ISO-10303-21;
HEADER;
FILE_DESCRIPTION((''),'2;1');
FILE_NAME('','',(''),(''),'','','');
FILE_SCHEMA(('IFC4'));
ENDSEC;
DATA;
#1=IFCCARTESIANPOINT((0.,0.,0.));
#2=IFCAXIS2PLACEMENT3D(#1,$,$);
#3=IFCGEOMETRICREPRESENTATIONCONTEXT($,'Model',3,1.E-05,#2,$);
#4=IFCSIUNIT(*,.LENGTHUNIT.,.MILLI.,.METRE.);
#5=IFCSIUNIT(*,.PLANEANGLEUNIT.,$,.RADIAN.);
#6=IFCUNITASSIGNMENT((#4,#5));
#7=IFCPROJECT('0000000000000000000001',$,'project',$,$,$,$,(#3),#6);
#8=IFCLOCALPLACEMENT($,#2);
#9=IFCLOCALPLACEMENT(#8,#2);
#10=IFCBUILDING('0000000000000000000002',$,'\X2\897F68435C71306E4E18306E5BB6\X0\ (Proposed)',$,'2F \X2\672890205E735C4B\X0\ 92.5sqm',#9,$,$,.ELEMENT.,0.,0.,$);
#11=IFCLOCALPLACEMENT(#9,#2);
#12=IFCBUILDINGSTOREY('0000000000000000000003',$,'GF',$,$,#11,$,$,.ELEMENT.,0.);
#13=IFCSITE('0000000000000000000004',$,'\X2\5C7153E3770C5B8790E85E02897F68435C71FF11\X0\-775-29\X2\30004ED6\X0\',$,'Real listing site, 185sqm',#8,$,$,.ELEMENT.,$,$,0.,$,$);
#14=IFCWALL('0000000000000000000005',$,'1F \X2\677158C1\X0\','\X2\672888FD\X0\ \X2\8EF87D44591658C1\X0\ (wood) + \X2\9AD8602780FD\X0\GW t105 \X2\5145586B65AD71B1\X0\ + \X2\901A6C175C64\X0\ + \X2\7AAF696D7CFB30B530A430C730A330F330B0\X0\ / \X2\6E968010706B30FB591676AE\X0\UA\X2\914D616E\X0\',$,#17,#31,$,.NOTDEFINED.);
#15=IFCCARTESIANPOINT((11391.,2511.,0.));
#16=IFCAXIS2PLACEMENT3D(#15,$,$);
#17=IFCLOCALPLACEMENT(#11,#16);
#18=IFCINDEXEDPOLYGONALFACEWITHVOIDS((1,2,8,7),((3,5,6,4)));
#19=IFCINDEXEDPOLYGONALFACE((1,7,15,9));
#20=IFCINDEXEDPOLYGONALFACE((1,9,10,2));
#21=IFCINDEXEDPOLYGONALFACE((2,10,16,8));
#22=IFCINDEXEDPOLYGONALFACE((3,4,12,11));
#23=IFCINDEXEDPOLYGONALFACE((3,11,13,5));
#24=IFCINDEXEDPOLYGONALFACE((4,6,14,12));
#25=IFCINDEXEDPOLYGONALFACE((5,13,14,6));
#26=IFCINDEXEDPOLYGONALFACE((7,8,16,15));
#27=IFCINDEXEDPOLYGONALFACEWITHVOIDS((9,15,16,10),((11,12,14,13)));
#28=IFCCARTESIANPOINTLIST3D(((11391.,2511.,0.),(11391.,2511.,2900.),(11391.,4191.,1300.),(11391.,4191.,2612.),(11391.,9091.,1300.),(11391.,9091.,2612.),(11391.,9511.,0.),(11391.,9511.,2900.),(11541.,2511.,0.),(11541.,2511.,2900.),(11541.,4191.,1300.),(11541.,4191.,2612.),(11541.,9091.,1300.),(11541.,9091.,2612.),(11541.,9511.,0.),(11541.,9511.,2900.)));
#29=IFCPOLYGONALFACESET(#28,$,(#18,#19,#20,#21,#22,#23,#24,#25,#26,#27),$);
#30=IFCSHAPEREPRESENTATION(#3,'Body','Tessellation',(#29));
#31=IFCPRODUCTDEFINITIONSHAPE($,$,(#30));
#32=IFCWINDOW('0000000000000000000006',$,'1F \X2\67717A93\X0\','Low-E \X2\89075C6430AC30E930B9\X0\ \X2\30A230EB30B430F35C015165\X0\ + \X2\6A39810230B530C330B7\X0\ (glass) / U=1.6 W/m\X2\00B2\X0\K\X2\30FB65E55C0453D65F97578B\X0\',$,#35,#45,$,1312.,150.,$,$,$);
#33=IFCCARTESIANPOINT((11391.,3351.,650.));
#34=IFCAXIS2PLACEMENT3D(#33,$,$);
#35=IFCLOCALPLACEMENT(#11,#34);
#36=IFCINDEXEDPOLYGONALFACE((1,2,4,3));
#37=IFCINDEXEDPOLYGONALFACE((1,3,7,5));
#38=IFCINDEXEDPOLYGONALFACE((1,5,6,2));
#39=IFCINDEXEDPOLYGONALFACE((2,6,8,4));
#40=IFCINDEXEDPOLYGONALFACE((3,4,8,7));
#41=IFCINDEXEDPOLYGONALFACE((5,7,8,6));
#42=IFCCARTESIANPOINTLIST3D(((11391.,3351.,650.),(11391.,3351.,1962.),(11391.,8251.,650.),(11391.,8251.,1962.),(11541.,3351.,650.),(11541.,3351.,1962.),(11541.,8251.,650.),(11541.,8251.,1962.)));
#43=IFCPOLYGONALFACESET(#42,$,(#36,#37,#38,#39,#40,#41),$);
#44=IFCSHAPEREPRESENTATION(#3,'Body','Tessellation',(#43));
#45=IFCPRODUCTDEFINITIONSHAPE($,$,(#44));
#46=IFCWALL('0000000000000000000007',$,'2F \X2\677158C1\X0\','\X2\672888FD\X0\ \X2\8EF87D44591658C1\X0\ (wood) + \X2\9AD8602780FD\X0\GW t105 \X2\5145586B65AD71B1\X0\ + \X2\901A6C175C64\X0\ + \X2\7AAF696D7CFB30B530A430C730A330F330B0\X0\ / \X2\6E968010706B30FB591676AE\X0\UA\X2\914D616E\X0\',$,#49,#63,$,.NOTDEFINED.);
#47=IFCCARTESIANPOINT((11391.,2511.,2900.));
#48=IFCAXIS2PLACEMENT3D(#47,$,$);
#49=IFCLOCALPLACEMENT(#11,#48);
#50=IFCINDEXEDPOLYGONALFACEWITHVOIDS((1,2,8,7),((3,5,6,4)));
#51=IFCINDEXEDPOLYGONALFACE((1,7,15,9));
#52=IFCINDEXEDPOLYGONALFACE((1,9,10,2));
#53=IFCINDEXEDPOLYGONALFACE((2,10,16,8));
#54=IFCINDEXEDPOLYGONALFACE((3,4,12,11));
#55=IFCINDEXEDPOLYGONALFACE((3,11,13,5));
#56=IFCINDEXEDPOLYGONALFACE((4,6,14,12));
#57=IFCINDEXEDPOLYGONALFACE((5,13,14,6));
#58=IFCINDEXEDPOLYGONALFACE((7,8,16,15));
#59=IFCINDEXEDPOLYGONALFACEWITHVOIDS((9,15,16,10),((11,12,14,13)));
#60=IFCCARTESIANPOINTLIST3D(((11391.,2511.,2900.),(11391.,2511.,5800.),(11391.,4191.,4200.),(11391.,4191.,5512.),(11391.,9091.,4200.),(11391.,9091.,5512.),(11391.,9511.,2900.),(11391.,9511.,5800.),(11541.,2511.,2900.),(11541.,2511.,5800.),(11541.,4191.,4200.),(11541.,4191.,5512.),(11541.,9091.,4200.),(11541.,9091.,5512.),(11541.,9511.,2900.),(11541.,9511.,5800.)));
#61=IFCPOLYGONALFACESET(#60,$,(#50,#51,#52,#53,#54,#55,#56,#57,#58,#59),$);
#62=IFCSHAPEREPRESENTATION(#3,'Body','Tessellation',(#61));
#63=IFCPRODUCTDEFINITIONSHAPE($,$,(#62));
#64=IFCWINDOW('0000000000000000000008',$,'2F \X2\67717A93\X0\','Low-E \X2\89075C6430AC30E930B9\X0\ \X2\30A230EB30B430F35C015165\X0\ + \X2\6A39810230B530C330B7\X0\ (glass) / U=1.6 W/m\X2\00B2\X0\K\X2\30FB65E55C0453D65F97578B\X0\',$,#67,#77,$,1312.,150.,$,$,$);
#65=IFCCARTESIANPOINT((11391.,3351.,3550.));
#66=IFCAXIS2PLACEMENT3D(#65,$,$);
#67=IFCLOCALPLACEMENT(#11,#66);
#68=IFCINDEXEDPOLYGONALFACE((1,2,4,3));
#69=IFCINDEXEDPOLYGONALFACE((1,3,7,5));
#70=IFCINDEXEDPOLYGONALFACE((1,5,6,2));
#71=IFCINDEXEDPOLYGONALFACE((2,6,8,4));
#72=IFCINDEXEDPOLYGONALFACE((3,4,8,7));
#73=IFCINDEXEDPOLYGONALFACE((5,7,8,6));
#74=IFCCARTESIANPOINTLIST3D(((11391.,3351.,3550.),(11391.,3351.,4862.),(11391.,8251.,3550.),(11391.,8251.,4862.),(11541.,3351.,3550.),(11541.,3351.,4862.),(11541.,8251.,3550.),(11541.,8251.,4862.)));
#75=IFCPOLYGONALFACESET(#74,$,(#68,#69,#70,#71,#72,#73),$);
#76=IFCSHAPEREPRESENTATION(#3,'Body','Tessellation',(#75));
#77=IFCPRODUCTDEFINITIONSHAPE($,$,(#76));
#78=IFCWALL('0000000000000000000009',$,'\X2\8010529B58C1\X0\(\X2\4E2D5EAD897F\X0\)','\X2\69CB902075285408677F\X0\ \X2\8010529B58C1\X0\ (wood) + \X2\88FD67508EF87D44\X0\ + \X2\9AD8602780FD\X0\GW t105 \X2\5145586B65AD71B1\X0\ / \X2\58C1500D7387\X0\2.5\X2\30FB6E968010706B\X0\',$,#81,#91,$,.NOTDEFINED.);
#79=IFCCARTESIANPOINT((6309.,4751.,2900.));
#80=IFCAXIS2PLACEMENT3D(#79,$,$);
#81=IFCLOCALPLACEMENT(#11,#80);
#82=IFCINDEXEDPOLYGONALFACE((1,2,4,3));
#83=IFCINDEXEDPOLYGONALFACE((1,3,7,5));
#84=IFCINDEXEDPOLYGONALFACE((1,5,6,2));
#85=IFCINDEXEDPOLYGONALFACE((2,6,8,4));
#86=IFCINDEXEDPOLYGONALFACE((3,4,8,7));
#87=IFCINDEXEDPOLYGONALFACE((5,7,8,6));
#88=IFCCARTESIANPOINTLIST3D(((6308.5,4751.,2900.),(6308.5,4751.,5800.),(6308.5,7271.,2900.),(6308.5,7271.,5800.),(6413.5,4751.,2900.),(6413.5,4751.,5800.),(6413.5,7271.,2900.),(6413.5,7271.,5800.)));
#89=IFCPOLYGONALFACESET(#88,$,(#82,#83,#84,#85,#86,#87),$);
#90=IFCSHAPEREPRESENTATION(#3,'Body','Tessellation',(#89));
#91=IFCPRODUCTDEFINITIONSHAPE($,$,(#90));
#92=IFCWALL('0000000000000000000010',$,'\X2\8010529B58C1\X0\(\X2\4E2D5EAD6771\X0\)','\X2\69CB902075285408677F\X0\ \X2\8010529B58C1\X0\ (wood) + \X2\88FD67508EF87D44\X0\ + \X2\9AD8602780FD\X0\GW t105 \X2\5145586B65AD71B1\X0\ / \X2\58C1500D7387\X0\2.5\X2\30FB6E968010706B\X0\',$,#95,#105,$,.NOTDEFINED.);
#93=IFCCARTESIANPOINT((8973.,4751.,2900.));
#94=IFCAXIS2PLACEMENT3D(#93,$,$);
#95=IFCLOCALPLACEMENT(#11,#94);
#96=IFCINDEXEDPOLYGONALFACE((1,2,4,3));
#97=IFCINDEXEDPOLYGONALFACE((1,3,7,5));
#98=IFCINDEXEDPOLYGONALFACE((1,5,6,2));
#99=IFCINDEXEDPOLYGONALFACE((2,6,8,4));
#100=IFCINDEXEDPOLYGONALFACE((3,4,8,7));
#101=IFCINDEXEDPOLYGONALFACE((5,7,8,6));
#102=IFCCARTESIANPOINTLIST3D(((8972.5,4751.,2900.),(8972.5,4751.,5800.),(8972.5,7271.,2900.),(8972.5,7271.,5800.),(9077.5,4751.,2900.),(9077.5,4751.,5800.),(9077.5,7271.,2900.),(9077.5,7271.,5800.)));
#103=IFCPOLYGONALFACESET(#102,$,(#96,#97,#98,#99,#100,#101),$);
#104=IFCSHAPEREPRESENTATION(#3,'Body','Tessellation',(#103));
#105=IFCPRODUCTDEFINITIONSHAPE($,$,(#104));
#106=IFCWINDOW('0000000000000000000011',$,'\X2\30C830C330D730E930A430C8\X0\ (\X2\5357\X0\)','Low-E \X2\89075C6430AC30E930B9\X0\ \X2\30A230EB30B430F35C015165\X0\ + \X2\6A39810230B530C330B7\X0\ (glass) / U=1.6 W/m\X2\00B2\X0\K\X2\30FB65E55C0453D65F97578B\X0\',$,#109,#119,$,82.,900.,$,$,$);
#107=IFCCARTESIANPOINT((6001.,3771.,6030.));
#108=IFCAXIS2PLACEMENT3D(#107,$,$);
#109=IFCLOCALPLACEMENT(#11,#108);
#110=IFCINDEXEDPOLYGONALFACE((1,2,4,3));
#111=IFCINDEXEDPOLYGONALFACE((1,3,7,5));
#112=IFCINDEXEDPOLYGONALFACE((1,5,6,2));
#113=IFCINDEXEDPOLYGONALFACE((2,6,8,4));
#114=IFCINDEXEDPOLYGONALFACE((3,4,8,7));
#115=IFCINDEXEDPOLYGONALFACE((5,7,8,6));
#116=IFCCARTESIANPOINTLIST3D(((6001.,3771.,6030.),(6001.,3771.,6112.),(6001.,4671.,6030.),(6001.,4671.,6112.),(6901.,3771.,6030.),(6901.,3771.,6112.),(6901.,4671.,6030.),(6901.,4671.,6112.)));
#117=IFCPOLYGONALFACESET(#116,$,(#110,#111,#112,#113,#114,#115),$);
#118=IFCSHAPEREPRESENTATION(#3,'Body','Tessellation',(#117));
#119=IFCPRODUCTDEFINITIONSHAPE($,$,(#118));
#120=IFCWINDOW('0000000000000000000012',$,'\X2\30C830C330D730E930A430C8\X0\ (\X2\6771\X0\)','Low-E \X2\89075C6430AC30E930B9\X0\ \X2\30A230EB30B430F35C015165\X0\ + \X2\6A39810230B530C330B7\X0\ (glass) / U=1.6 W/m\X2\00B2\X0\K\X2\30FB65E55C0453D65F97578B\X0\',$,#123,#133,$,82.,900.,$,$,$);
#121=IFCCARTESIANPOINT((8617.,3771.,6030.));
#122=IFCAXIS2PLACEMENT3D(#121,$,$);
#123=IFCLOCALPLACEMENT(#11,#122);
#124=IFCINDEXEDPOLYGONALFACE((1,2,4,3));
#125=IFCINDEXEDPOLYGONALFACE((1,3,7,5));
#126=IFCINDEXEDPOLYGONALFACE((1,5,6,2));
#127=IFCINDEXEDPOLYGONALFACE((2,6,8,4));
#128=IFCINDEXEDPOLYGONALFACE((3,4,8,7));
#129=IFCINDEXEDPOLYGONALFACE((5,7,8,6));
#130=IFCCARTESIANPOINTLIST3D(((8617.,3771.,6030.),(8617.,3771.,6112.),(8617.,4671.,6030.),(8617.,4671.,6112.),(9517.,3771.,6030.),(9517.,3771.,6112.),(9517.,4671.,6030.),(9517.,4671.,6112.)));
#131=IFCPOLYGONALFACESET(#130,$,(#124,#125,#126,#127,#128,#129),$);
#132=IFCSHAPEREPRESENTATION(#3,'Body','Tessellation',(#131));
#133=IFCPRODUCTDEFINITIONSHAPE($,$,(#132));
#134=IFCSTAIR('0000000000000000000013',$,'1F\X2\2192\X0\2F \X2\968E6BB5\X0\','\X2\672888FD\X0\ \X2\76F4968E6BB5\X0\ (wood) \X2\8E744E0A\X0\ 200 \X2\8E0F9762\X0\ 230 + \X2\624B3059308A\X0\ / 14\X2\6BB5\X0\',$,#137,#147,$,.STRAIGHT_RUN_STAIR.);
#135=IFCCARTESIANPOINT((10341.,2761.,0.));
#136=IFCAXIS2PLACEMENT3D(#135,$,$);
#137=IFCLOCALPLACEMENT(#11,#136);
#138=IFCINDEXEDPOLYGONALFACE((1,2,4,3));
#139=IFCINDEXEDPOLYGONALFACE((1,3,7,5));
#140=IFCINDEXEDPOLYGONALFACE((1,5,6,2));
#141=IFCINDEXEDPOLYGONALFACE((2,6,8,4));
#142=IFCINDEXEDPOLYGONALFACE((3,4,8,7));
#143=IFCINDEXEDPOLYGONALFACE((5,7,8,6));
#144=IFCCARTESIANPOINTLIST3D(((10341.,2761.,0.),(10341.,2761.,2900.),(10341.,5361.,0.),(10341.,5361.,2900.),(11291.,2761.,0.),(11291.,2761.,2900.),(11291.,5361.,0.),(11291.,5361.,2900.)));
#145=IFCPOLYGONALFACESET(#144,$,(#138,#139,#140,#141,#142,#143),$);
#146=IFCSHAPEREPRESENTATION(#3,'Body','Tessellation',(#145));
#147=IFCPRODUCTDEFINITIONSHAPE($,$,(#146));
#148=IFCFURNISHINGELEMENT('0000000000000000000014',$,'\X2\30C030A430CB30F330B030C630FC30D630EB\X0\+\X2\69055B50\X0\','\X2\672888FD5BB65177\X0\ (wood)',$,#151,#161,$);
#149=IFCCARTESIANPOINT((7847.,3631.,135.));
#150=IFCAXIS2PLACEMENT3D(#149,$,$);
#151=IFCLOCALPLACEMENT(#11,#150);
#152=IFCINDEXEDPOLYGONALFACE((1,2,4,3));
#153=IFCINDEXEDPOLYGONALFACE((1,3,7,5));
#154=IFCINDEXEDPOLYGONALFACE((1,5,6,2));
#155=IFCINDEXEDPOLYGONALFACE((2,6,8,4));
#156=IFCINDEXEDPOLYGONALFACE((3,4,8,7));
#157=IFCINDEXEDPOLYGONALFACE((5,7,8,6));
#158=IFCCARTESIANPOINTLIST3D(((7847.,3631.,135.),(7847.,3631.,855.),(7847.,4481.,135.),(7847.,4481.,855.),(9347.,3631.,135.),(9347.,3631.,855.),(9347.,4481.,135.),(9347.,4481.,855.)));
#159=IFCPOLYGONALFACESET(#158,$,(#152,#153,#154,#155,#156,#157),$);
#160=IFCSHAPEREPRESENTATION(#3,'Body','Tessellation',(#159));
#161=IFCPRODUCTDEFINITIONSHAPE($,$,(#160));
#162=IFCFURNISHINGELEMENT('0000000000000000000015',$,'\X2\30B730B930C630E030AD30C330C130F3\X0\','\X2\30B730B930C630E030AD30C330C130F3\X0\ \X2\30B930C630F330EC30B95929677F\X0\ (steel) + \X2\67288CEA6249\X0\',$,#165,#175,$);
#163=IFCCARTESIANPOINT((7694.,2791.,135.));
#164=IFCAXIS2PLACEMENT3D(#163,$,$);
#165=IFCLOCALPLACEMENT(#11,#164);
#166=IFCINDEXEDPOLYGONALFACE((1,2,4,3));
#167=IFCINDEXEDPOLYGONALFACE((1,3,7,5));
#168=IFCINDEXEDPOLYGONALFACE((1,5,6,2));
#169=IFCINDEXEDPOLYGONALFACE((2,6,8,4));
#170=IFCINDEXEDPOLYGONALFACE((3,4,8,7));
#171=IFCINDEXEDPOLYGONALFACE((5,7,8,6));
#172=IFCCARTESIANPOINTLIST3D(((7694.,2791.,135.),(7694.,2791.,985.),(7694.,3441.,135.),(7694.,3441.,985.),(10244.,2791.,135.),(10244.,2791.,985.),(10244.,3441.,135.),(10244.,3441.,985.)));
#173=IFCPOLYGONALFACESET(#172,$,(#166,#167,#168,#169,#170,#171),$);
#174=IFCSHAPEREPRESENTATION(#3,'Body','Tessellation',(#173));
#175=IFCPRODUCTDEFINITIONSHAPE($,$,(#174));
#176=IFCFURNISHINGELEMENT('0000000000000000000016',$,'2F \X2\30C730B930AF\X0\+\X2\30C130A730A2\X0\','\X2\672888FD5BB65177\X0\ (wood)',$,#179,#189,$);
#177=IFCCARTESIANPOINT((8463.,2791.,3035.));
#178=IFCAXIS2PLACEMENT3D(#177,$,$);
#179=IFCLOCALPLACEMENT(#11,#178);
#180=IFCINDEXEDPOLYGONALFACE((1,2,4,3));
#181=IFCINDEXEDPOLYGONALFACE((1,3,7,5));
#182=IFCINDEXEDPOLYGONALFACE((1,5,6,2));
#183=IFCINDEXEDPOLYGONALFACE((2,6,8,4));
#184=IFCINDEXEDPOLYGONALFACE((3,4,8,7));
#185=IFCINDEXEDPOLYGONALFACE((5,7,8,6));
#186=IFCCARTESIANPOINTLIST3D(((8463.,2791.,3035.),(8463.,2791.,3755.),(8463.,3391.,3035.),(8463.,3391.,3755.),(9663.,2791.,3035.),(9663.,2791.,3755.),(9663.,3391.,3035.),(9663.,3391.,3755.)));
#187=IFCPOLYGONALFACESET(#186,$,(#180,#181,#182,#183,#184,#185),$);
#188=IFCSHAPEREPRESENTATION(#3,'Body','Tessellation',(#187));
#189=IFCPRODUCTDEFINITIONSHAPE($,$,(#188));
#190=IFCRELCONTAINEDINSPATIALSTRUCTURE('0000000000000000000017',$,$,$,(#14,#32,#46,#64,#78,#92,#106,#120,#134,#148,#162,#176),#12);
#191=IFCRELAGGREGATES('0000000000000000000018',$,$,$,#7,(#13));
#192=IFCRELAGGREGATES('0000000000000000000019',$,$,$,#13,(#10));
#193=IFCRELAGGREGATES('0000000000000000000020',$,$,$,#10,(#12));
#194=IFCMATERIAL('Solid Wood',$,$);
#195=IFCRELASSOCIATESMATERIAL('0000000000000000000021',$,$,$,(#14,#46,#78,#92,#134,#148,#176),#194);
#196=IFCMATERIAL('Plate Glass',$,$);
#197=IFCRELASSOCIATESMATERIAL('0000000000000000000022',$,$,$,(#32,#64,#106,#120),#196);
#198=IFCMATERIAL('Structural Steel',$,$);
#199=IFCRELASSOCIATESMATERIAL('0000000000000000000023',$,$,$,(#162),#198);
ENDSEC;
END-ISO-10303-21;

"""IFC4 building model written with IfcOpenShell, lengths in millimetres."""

from ifc_helpers import new_model, si_unit, frame, frame_2d, origin, place, context, project, spatial, rectangle, extrude, material, element, fill, save


model = new_model("IFC4")

# Units and contexts
model_context = context("Model", 3, precision=1e-05, world=origin())
ifc_project = project(units=[si_unit("LENGTHUNIT", "METRE", prefix="MILLI"), si_unit("PLANEANGLEUNIT", "RADIAN")], contexts=[model_context])

# Site, building, storey
site_placement = place(None, origin())
site = spatial("IfcSite", under=ifc_project, at=site_placement, Name="山口県宇部市西桃山１-775-29　他", ObjectType="Real listing site, 185sqm", CompositionType="ELEMENT", RefElevation=0.0)
building_placement = place(site_placement, origin())
building = spatial("IfcBuilding", under=site, at=building_placement, Name="西桃山の丘の家 (Proposed)", ObjectType="2F 木造平屋 92.5sqm", CompositionType="ELEMENT", ElevationOfRefHeight=0.0, ElevationOfTerrain=0.0)
storey_placement = place(building_placement, origin())
storey = spatial("IfcBuildingStorey", under=building, at=storey_placement, Name="GF", CompositionType="ELEMENT", Elevation=0.0)

# Shared definitions
ifc_material_1 = material(Name="Solid Wood")

# Wall, opening, window
wall_1_placement = place(storey_placement, frame((11391.0, 2511.0, 0.0)))
wall_1 = element("IfcWall", 1, at=wall_1_placement, inside=storey, material=ifc_material_1, Name="1F 東壁", Description="木製 軸組外壁 (wood) + 高性能GW t105 充填断熱 + 通気層 + 窯業系サイディング / 準耐火・外皮UA配慮", PredefinedType="NOTDEFINED", context=model_context, shape_type="SweptSolid", body=[
    extrude(rectangle(XDim=150.0, YDim=7000.0, at=frame_2d((75.0, 3500.0))), frame((11391.0, 2511.0, 0.0)), (0.0, 0.0, 1.0), 2900.0),
])
opening_1_placement = place(storey_placement, frame((11391.0, 3351.0, 650.0)))
opening_1 = element("IfcOpeningElement", 2, at=opening_1_placement, cuts=wall_1, PredefinedType="NOTDEFINED", context=model_context, shape_type="SweptSolid", body=[
    extrude(rectangle(XDim=150.0, YDim=4900.0, at=frame_2d((75.0, 2450.0))), frame((11391.0, 3351.0, 650.0)), (0.0, 0.0, 1.0), 1312.0),
])
ifc_material_2 = material(Name="Plate Glass")
window_1_placement = place(storey_placement, frame((11391.0, 3351.0, 650.0)))
window_1 = element("IfcWindow", 3, at=window_1_placement, inside=storey, material=ifc_material_2, Name="1F 東窓", Description="Low-E 複層ガラス アルゴン封入 + 樹脂サッシ (glass) / U=1.6 W/m²K・日射取得型", OverallHeight=1312.0, OverallWidth=150.0, context=model_context, shape_type="SweptSolid", body=[
    extrude(rectangle(XDim=150.0, YDim=4900.0, at=frame_2d((75.0, 2450.0))), frame((11391.0, 3351.0, 650.0)), (0.0, 0.0, 1.0), 1312.0),
])
fill(opening_1, window_1)

# Wall, opening, window
wall_2_placement = place(storey_placement, frame((11391.0, 2511.0, 2900.0)))
wall_2 = element("IfcWall", 4, at=wall_2_placement, inside=storey, material=ifc_material_1, Name="2F 東壁", Description="木製 軸組外壁 (wood) + 高性能GW t105 充填断熱 + 通気層 + 窯業系サイディング / 準耐火・外皮UA配慮", PredefinedType="NOTDEFINED", context=model_context, shape_type="SweptSolid", body=[
    extrude(rectangle(XDim=150.0, YDim=7000.0, at=frame_2d((75.0, 3500.0))), frame((11391.0, 2511.0, 2900.0)), (0.0, 0.0, 1.0), 2900.0),
])
opening_2_placement = place(storey_placement, frame((11391.0, 3351.0, 3550.0)))
opening_2 = element("IfcOpeningElement", 5, at=opening_2_placement, cuts=wall_2, PredefinedType="NOTDEFINED", context=model_context, shape_type="SweptSolid", body=[
    extrude(rectangle(XDim=150.0, YDim=4900.0, at=frame_2d((75.0, 2450.0))), frame((11391.0, 3351.0, 3550.0)), (0.0, 0.0, 1.0), 1312.0),
])
window_2_placement = place(storey_placement, frame((11391.0, 3351.0, 3550.0)))
window_2 = element("IfcWindow", 6, at=window_2_placement, inside=storey, material=ifc_material_2, Name="2F 東窓", Description="Low-E 複層ガラス アルゴン封入 + 樹脂サッシ (glass) / U=1.6 W/m²K・日射取得型", OverallHeight=1312.0, OverallWidth=150.0, context=model_context, shape_type="SweptSolid", body=[
    extrude(rectangle(XDim=150.0, YDim=4900.0, at=frame_2d((75.0, 2450.0))), frame((11391.0, 3351.0, 3550.0)), (0.0, 0.0, 1.0), 1312.0),
])
fill(opening_2, window_2)

# Walls
wall_3_placement = place(storey_placement, frame((6309.0, 4751.0, 2900.0)))
element("IfcWall", 7, at=wall_3_placement, inside=storey, material=ifc_material_1, Name="耐力壁(中庭西)", Description="構造用合板 耐力壁 (wood) + 製材軸組 + 高性能GW t105 充填断熱 / 壁倍率2.5・準耐火", PredefinedType="NOTDEFINED", context=model_context, shape_type="SweptSolid", body=[
    extrude(rectangle(XDim=105.0, YDim=2520.0, at=frame_2d((52.0, 1260.0))), frame((6309.0, 4751.0, 2900.0)), (0.0, 0.0, 1.0), 2900.0),
])
wall_4_placement = place(storey_placement, frame((8973.0, 4751.0, 2900.0)))
element("IfcWall", 8, at=wall_4_placement, inside=storey, material=ifc_material_1, Name="耐力壁(中庭東)", Description="構造用合板 耐力壁 (wood) + 製材軸組 + 高性能GW t105 充填断熱 / 壁倍率2.5・準耐火", PredefinedType="NOTDEFINED", context=model_context, shape_type="SweptSolid", body=[
    extrude(rectangle(XDim=105.0, YDim=2520.0, at=frame_2d((52.0, 1260.0))), frame((8973.0, 4751.0, 2900.0)), (0.0, 0.0, 1.0), 2900.0),
])

# Windows
window_3_placement = place(storey_placement, frame((6001.0, 3771.0, 6030.0)))
element("IfcWindow", 9, at=window_3_placement, inside=storey, material=ifc_material_2, Name="トップライト (南)", Description="Low-E 複層ガラス アルゴン封入 + 樹脂サッシ (glass) / U=1.6 W/m²K・日射取得型", OverallHeight=82.0, OverallWidth=900.0, context=model_context, shape_type="SweptSolid", body=[
    extrude(rectangle(XDim=900.0, YDim=900.0, at=frame_2d((450.0, 450.0))), frame((6001.0, 3771.0, 6030.0)), (0.0, 0.0, 1.0), 82.0),
])
window_4_placement = place(storey_placement, frame((8617.0, 3771.0, 6030.0)))
element("IfcWindow", 10, at=window_4_placement, inside=storey, material=ifc_material_2, Name="トップライト (東)", Description="Low-E 複層ガラス アルゴン封入 + 樹脂サッシ (glass) / U=1.6 W/m²K・日射取得型", OverallHeight=82.0, OverallWidth=900.0, context=model_context, shape_type="SweptSolid", body=[
    extrude(rectangle(XDim=900.0, YDim=900.0, at=frame_2d((450.0, 450.0))), frame((8617.0, 3771.0, 6030.0)), (0.0, 0.0, 1.0), 82.0),
])

# Stair
stair_placement = place(storey_placement, frame((10341.0, 2761.0, 0.0)))
element("IfcStair", 11, at=stair_placement, inside=storey, material=ifc_material_1, Name="1F→2F 階段", Description="木製 直階段 (wood) 蹴上 200 踏面 230 + 手すり / 14段", PredefinedType="STRAIGHT_RUN_STAIR", context=model_context, shape_type="SweptSolid", body=[
    extrude(rectangle(XDim=950.0, YDim=2600.0, at=frame_2d((475.0, 1300.0))), frame((10341.0, 2761.0, 0.0)), (0.0, 0.0, 1.0), 2900.0),
])

# Furnishing elements
furnishing_1_placement = place(storey_placement, frame((7847.0, 3631.0, 135.0)))
element("IfcFurnishingElement", 12, at=furnishing_1_placement, inside=storey, material=ifc_material_1, Name="ダイニングテーブル+椅子", Description="木製家具 (wood)", context=model_context, shape_type="SweptSolid", body=[
    extrude(rectangle(XDim=1500.0, YDim=850.0, at=frame_2d((750.0, 425.0))), frame((7847.0, 3631.0, 135.0)), (0.0, 0.0, 1.0), 720.0),
])
ifc_material_3 = material(Name="Structural Steel")
furnishing_2_placement = place(storey_placement, frame((7694.0, 2791.0, 135.0)))
element("IfcFurnishingElement", 13, at=furnishing_2_placement, inside=storey, material=ifc_material_3, Name="システムキッチン", Description="システムキッチン ステンレス天板 (steel) + 木質扉", context=model_context, shape_type="SweptSolid", body=[
    extrude(rectangle(XDim=2550.0, YDim=650.0, at=frame_2d((1275.0, 325.0))), frame((7694.0, 2791.0, 135.0)), (0.0, 0.0, 1.0), 850.0),
])
furnishing_3_placement = place(storey_placement, frame((8463.0, 2791.0, 3035.0)))
element("IfcFurnishingElement", 14, at=furnishing_3_placement, inside=storey, material=ifc_material_1, Name="2F デスク+チェア", Description="木製家具 (wood)", context=model_context, shape_type="SweptSolid", body=[
    extrude(rectangle(XDim=1200.0, YDim=600.0, at=frame_2d((600.0, 300.0))), frame((8463.0, 2791.0, 3035.0)), (0.0, 0.0, 1.0), 720.0),
])

save(model, "model.ifc")
